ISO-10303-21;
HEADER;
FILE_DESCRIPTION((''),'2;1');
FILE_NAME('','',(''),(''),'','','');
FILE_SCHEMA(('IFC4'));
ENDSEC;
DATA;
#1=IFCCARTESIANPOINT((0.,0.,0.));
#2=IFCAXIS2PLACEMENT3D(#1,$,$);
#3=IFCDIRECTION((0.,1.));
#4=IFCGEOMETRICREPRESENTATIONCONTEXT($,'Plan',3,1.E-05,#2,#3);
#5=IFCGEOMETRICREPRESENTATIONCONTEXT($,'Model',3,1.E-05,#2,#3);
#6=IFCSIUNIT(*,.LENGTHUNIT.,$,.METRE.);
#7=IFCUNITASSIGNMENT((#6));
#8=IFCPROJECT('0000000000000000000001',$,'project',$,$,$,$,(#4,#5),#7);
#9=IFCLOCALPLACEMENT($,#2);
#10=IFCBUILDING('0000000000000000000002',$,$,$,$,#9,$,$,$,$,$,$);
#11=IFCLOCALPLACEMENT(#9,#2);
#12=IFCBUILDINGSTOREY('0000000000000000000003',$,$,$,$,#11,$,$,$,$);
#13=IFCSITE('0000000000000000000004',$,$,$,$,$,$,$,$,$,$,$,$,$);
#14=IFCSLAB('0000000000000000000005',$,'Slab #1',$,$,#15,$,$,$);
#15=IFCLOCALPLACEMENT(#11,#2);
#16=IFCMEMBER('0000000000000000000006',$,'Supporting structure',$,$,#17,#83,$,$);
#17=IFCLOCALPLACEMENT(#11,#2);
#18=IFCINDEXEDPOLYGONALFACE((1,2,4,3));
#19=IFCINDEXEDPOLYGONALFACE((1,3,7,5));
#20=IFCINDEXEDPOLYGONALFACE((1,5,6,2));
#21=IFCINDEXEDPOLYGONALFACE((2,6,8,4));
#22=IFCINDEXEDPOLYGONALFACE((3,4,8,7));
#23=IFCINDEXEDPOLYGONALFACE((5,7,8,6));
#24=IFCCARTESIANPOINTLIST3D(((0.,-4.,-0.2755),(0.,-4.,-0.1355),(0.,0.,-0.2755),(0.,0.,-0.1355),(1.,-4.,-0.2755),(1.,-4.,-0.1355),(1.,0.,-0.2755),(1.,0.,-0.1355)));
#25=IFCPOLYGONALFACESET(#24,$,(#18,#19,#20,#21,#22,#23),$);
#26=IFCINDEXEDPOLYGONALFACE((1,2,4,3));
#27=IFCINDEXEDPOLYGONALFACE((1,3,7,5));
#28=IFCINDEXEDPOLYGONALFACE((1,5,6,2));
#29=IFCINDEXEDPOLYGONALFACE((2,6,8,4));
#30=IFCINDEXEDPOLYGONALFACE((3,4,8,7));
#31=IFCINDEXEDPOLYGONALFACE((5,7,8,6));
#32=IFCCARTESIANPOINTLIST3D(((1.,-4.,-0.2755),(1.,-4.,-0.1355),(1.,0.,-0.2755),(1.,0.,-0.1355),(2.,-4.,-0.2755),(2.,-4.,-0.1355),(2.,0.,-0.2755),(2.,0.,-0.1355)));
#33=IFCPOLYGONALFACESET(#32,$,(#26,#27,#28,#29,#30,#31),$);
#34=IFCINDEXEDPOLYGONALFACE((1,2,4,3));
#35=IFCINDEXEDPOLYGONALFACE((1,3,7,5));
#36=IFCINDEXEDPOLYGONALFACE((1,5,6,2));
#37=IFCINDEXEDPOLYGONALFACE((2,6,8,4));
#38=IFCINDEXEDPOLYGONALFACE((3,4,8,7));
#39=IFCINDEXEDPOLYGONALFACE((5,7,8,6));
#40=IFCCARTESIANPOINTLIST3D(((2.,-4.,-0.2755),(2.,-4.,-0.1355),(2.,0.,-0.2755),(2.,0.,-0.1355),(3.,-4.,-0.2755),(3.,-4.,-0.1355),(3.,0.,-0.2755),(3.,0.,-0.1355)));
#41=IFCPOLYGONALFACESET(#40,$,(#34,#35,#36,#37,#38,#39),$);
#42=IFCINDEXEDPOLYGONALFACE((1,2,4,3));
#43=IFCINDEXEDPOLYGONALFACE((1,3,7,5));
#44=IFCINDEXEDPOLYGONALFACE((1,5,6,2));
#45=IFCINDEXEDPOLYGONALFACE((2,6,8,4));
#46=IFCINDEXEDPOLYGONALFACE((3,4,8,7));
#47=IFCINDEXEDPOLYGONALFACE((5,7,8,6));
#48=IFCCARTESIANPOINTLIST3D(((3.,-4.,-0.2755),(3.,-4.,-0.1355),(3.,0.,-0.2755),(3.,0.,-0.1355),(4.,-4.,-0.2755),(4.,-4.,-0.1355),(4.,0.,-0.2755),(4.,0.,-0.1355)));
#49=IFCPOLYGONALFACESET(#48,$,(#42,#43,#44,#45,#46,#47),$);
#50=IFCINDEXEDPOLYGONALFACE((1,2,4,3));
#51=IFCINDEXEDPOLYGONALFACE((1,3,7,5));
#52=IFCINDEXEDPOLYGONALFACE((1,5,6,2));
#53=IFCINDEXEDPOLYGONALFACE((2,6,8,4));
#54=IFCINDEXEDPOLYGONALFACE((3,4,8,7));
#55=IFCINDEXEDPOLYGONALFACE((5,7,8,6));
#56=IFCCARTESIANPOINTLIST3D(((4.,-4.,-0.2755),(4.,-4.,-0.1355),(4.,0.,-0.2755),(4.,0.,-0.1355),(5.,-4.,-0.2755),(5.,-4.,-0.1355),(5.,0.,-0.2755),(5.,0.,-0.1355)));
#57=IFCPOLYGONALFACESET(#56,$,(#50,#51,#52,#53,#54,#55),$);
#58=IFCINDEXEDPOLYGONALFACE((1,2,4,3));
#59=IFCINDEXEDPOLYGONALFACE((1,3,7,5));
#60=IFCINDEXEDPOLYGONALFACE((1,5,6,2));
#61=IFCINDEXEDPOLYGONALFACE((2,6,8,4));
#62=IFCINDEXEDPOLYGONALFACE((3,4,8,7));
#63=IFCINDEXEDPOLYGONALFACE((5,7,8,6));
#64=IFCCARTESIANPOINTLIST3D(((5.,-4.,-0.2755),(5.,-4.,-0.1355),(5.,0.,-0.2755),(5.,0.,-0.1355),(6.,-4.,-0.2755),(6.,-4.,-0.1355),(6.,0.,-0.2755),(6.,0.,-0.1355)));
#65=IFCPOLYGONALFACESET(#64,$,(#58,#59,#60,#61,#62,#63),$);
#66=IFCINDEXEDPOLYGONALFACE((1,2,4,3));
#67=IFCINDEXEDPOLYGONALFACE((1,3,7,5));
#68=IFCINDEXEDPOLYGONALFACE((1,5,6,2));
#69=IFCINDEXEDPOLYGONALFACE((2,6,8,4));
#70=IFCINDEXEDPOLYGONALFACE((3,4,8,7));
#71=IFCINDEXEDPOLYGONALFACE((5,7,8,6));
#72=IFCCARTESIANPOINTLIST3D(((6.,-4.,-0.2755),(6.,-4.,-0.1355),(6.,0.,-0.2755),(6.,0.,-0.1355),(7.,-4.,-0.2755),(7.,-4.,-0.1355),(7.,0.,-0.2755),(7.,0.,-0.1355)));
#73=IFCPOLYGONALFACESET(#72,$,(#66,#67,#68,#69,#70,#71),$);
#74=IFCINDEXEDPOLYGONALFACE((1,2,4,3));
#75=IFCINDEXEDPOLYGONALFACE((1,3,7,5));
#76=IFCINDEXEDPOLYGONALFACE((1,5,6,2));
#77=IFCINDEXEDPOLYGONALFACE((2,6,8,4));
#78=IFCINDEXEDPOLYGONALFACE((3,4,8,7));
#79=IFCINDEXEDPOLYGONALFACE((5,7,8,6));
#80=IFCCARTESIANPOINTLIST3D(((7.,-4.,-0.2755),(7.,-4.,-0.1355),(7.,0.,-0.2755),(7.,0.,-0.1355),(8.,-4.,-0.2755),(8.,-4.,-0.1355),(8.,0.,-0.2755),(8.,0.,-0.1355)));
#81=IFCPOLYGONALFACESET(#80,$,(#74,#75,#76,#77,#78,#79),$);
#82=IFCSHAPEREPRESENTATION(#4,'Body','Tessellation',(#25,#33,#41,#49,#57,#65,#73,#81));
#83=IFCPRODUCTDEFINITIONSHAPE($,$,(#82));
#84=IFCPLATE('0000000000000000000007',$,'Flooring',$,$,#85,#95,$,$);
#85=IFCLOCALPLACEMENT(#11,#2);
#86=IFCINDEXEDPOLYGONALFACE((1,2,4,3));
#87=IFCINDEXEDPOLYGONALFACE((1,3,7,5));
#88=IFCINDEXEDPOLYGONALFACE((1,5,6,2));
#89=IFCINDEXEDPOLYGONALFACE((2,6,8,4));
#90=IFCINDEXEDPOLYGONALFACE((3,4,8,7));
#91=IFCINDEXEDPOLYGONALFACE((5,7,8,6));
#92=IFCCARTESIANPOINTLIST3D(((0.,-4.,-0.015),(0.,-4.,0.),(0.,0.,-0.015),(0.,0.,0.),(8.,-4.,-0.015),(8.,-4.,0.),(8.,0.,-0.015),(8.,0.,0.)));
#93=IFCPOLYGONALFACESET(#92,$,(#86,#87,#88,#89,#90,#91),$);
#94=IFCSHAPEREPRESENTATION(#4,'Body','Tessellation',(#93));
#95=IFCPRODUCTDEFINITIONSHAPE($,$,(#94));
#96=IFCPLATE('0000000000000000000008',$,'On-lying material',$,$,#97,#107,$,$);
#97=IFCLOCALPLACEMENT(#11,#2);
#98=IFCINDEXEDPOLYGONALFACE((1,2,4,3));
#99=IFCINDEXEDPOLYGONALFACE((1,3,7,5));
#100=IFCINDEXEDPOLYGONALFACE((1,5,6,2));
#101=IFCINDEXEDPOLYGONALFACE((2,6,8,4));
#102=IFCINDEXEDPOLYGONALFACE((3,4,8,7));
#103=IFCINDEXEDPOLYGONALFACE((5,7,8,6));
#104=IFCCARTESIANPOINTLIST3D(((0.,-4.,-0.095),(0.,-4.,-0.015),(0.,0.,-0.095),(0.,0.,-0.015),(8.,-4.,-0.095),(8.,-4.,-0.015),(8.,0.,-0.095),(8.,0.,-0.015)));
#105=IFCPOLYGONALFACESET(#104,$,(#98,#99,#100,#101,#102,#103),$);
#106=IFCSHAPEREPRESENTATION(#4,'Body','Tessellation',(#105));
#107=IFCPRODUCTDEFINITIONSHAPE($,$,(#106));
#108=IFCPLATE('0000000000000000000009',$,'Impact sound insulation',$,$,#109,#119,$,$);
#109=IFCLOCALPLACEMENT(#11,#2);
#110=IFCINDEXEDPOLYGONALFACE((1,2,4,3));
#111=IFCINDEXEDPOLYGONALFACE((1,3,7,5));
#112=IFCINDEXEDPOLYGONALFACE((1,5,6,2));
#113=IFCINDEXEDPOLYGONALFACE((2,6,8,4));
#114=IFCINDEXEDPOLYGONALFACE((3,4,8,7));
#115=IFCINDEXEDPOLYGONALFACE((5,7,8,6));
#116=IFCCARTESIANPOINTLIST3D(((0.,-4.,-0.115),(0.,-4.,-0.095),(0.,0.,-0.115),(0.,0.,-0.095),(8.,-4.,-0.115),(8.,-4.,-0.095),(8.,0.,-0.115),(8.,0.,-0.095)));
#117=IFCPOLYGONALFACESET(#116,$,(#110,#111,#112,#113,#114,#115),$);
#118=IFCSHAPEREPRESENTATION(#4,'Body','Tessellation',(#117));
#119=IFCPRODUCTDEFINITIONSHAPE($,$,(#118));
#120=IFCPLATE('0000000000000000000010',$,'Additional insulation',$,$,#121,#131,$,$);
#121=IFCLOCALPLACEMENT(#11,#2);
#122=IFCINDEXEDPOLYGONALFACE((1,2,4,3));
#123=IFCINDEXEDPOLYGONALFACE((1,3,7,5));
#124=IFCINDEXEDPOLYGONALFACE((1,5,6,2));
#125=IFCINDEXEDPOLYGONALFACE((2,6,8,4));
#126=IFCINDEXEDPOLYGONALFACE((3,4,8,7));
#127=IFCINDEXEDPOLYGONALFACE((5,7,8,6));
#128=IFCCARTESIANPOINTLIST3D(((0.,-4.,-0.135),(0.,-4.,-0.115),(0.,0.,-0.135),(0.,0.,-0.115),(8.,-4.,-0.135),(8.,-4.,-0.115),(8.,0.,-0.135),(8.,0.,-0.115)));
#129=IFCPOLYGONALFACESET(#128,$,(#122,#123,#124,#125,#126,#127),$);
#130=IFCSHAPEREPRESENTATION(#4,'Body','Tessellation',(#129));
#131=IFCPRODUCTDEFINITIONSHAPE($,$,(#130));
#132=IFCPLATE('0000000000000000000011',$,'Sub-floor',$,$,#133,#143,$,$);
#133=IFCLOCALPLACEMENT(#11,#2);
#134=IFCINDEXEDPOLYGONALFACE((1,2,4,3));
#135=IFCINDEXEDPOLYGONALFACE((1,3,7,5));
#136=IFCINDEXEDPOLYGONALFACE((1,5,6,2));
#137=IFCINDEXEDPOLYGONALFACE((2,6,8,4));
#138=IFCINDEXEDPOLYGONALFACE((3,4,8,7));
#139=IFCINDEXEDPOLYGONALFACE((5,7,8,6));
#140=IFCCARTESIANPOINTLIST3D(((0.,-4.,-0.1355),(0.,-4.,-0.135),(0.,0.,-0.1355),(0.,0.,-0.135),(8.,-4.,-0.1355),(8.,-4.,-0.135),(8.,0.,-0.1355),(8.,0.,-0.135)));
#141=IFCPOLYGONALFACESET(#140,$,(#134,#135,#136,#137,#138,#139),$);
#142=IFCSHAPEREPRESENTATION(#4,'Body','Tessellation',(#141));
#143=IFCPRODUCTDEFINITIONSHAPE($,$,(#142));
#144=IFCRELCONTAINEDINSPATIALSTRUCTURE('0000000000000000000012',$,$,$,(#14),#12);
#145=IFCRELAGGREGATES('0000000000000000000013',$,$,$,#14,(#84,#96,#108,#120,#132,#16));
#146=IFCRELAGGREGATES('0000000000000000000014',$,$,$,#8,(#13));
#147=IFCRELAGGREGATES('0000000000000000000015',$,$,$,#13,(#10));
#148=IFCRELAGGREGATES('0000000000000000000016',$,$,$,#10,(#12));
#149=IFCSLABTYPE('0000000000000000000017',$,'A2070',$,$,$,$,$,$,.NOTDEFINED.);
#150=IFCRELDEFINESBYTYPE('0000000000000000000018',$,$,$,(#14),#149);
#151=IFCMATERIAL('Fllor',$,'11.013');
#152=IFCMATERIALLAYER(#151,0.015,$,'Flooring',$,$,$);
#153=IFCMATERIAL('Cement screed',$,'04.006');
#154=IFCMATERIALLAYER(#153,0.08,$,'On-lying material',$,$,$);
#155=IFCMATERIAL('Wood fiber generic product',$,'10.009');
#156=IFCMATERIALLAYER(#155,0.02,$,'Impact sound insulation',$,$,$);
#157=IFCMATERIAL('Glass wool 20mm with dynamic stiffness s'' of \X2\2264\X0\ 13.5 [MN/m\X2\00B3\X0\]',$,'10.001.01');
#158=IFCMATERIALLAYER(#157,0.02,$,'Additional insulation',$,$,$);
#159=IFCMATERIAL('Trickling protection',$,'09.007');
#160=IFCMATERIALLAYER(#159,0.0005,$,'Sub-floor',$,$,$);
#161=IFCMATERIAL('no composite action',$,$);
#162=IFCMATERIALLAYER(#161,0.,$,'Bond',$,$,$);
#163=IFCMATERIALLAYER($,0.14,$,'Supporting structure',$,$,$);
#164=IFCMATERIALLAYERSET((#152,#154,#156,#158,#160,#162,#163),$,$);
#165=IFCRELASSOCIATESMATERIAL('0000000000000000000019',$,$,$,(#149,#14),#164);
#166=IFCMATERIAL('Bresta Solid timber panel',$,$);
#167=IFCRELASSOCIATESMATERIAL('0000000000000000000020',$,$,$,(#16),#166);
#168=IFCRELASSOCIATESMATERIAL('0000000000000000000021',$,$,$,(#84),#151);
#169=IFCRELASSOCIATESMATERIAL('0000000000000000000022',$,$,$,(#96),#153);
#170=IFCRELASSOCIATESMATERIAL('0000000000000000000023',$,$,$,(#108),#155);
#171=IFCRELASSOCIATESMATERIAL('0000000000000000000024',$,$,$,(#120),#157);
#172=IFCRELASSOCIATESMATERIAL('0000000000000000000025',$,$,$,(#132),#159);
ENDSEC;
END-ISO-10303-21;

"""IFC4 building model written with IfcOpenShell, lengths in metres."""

from ifc_helpers import new_model, si_unit, direction, frame, frame_2d, origin, origin_with_axes, place, context, project, spatial, rectangle, extrude, material, layer, layer_set, type_object, element, aggregate, save


model = new_model("IFC4")

# Units and contexts
plan_context = context("Plan", 3, precision=1e-05, world=origin(), true_north=direction((0.0, 1.0)))
model_context = context("Model", 3, precision=1e-05, world=origin(), true_north=direction((0.0, 1.0)))
ifc_project = project(units=[si_unit("LENGTHUNIT", "METRE")], contexts=[plan_context, model_context])

# Site, building, storey
site = spatial("IfcSite", under=ifc_project)
building_placement = place(None, origin())
building = spatial("IfcBuilding", under=site, at=building_placement)
storey_placement = place(building_placement, origin())
storey = spatial("IfcBuildingStorey", under=building, at=storey_placement)

# Slab, member, plates
ifc_material_1 = material(Name="Fllor", Category="11.013")
ifc_layer_1 = layer(ifc_material_1, 0.015, Name="Flooring")
ifc_material_2 = material(Name="Cement screed", Category="04.006")
ifc_layer_2 = layer(ifc_material_2, 0.08, Name="On-lying material")
ifc_material_3 = material(Name="Wood fiber generic product", Category="10.009")
ifc_layer_3 = layer(ifc_material_3, 0.02, Name="Impact sound insulation")
ifc_material_4 = material(Name="Glass wool 20mm with dynamic stiffness s' of ≤ 13.5 [MN/m³]", Category="10.001.01")
ifc_layer_4 = layer(ifc_material_4, 0.02, Name="Additional insulation")
ifc_material_5 = material(Name="Trickling protection", Category="09.007")
ifc_layer_5 = layer(ifc_material_5, 0.0005, Name="Sub-floor")
ifc_material_6 = material(Name="no composite action")
ifc_layer_6 = layer(ifc_material_6, 0.0, Name="Bond")
ifc_layer_7 = layer(None, 0.14, Name="Supporting structure")
ifc_layer_set = layer_set([ifc_layer_1, ifc_layer_2, ifc_layer_3, ifc_layer_4, ifc_layer_5, ifc_layer_6, ifc_layer_7])
slab_type = type_object("IfcSlabType", Name="A2070", PredefinedType="NOTDEFINED", material=ifc_layer_set)
slab_placement = place(None, frame((0.0, 0.0, 0.0), z_axis=(0.0, 0.0, -1.0), x_axis=(1.0, 0.0, 0.0)))
slab = element("IfcSlab", 1, at=slab_placement, inside=storey, type_object=slab_type, material=ifc_layer_set, Name="Slab #1")
ifc_material_7 = material(Name="Bresta Solid timber panel")
member_placement = place(slab_placement, origin())
member = element("IfcMember", 2, at=member_placement, material=ifc_material_7, Name="Supporting structure", context=plan_context, shape_type="SweptSolid", body=[
    extrude(rectangle(XDim=1.0, YDim=0.14, at=frame_2d((0.5, 0.07), x_axis=(1.0, 0.0))), frame((0.0, 4.0, 0.1355), z_axis=(0.0, -1.0, 0.0), x_axis=(1.0, 0.0, 0.0)), (0.0, 0.0, 1.0), 4.0),
    extrude(rectangle(XDim=1.0, YDim=0.14, at=frame_2d((0.5, 0.07), x_axis=(1.0, 0.0))), frame((1.0, 4.0, 0.1355), z_axis=(0.0, -1.0, 0.0), x_axis=(1.0, 0.0, 0.0)), (0.0, 0.0, 1.0), 4.0),
    extrude(rectangle(XDim=1.0, YDim=0.14, at=frame_2d((0.5, 0.07), x_axis=(1.0, 0.0))), frame((2.0, 4.0, 0.1355), z_axis=(0.0, -1.0, 0.0), x_axis=(1.0, 0.0, 0.0)), (0.0, 0.0, 1.0), 4.0),
    extrude(rectangle(XDim=1.0, YDim=0.14, at=frame_2d((0.5, 0.07), x_axis=(1.0, 0.0))), frame((3.0, 4.0, 0.1355), z_axis=(0.0, -1.0, 0.0), x_axis=(1.0, 0.0, 0.0)), (0.0, 0.0, 1.0), 4.0),
    extrude(rectangle(XDim=1.0, YDim=0.14, at=frame_2d((0.5, 0.07), x_axis=(1.0, 0.0))), frame((4.0, 4.0, 0.1355), z_axis=(0.0, -1.0, 0.0), x_axis=(1.0, 0.0, 0.0)), (0.0, 0.0, 1.0), 4.0),
    extrude(rectangle(XDim=1.0, YDim=0.14, at=frame_2d((0.5, 0.07), x_axis=(1.0, 0.0))), frame((5.0, 4.0, 0.1355), z_axis=(0.0, -1.0, 0.0), x_axis=(1.0, 0.0, 0.0)), (0.0, 0.0, 1.0), 4.0),
    extrude(rectangle(XDim=1.0, YDim=0.14, at=frame_2d((0.5, 0.07), x_axis=(1.0, 0.0))), frame((6.0, 4.0, 0.1355), z_axis=(0.0, -1.0, 0.0), x_axis=(1.0, 0.0, 0.0)), (0.0, 0.0, 1.0), 4.0),
    extrude(rectangle(XDim=1.0, YDim=0.14, at=frame_2d((0.5, 0.07), x_axis=(1.0, 0.0))), frame((7.0, 4.0, 0.1355), z_axis=(0.0, -1.0, 0.0), x_axis=(1.0, 0.0, 0.0)), (0.0, 0.0, 1.0), 4.0),
])
plate_1_placement = place(slab_placement, origin())
plate_1 = element("IfcPlate", 3, at=plate_1_placement, material=ifc_material_1, Name="Flooring", context=plan_context, shape_type="SweptSolid", body=[
    extrude(rectangle(XDim=8.0, YDim=4.0, at=frame_2d((4.0, 2.0), x_axis=(1.0, 0.0))), origin_with_axes(), (0.0, 0.0, 1.0), 0.015),
])
plate_2_placement = place(slab_placement, origin())
plate_2 = element("IfcPlate", 4, at=plate_2_placement, material=ifc_material_2, Name="On-lying material", context=plan_context, shape_type="SweptSolid", body=[
    extrude(rectangle(XDim=8.0, YDim=4.0, at=frame_2d((4.0, 2.0), x_axis=(1.0, 0.0))), frame((0.0, 0.0, 0.015), z_axis=(0.0, 0.0, 1.0), x_axis=(1.0, 0.0, 0.0)), (0.0, 0.0, 1.0), 0.08),
])
plate_3_placement = place(slab_placement, origin())
plate_3 = element("IfcPlate", 5, at=plate_3_placement, material=ifc_material_3, Name="Impact sound insulation", context=plan_context, shape_type="SweptSolid", body=[
    extrude(rectangle(XDim=8.0, YDim=4.0, at=frame_2d((4.0, 2.0), x_axis=(1.0, 0.0))), frame((0.0, 0.0, 0.095), z_axis=(0.0, 0.0, 1.0), x_axis=(1.0, 0.0, 0.0)), (0.0, 0.0, 1.0), 0.02),
])
plate_4_placement = place(slab_placement, origin())
plate_4 = element("IfcPlate", 6, at=plate_4_placement, material=ifc_material_4, Name="Additional insulation", context=plan_context, shape_type="SweptSolid", body=[
    extrude(rectangle(XDim=8.0, YDim=4.0, at=frame_2d((4.0, 2.0), x_axis=(1.0, 0.0))), frame((0.0, 0.0, 0.115), z_axis=(0.0, 0.0, 1.0), x_axis=(1.0, 0.0, 0.0)), (0.0, 0.0, 1.0), 0.02),
])
plate_5_placement = place(slab_placement, origin())
plate_5 = element("IfcPlate", 7, at=plate_5_placement, material=ifc_material_5, Name="Sub-floor", context=plan_context, shape_type="SweptSolid", body=[
    extrude(rectangle(XDim=8.0, YDim=4.0, at=frame_2d((4.0, 2.0), x_axis=(1.0, 0.0))), frame((0.0, 0.0, 0.135), z_axis=(0.0, 0.0, 1.0), x_axis=(1.0, 0.0, 0.0)), (0.0, 0.0, 1.0), 0.0005),
])
aggregate(slab, [plate_1, plate_2, plate_3, plate_4, plate_5, member])

save(model, "model.ifc")
